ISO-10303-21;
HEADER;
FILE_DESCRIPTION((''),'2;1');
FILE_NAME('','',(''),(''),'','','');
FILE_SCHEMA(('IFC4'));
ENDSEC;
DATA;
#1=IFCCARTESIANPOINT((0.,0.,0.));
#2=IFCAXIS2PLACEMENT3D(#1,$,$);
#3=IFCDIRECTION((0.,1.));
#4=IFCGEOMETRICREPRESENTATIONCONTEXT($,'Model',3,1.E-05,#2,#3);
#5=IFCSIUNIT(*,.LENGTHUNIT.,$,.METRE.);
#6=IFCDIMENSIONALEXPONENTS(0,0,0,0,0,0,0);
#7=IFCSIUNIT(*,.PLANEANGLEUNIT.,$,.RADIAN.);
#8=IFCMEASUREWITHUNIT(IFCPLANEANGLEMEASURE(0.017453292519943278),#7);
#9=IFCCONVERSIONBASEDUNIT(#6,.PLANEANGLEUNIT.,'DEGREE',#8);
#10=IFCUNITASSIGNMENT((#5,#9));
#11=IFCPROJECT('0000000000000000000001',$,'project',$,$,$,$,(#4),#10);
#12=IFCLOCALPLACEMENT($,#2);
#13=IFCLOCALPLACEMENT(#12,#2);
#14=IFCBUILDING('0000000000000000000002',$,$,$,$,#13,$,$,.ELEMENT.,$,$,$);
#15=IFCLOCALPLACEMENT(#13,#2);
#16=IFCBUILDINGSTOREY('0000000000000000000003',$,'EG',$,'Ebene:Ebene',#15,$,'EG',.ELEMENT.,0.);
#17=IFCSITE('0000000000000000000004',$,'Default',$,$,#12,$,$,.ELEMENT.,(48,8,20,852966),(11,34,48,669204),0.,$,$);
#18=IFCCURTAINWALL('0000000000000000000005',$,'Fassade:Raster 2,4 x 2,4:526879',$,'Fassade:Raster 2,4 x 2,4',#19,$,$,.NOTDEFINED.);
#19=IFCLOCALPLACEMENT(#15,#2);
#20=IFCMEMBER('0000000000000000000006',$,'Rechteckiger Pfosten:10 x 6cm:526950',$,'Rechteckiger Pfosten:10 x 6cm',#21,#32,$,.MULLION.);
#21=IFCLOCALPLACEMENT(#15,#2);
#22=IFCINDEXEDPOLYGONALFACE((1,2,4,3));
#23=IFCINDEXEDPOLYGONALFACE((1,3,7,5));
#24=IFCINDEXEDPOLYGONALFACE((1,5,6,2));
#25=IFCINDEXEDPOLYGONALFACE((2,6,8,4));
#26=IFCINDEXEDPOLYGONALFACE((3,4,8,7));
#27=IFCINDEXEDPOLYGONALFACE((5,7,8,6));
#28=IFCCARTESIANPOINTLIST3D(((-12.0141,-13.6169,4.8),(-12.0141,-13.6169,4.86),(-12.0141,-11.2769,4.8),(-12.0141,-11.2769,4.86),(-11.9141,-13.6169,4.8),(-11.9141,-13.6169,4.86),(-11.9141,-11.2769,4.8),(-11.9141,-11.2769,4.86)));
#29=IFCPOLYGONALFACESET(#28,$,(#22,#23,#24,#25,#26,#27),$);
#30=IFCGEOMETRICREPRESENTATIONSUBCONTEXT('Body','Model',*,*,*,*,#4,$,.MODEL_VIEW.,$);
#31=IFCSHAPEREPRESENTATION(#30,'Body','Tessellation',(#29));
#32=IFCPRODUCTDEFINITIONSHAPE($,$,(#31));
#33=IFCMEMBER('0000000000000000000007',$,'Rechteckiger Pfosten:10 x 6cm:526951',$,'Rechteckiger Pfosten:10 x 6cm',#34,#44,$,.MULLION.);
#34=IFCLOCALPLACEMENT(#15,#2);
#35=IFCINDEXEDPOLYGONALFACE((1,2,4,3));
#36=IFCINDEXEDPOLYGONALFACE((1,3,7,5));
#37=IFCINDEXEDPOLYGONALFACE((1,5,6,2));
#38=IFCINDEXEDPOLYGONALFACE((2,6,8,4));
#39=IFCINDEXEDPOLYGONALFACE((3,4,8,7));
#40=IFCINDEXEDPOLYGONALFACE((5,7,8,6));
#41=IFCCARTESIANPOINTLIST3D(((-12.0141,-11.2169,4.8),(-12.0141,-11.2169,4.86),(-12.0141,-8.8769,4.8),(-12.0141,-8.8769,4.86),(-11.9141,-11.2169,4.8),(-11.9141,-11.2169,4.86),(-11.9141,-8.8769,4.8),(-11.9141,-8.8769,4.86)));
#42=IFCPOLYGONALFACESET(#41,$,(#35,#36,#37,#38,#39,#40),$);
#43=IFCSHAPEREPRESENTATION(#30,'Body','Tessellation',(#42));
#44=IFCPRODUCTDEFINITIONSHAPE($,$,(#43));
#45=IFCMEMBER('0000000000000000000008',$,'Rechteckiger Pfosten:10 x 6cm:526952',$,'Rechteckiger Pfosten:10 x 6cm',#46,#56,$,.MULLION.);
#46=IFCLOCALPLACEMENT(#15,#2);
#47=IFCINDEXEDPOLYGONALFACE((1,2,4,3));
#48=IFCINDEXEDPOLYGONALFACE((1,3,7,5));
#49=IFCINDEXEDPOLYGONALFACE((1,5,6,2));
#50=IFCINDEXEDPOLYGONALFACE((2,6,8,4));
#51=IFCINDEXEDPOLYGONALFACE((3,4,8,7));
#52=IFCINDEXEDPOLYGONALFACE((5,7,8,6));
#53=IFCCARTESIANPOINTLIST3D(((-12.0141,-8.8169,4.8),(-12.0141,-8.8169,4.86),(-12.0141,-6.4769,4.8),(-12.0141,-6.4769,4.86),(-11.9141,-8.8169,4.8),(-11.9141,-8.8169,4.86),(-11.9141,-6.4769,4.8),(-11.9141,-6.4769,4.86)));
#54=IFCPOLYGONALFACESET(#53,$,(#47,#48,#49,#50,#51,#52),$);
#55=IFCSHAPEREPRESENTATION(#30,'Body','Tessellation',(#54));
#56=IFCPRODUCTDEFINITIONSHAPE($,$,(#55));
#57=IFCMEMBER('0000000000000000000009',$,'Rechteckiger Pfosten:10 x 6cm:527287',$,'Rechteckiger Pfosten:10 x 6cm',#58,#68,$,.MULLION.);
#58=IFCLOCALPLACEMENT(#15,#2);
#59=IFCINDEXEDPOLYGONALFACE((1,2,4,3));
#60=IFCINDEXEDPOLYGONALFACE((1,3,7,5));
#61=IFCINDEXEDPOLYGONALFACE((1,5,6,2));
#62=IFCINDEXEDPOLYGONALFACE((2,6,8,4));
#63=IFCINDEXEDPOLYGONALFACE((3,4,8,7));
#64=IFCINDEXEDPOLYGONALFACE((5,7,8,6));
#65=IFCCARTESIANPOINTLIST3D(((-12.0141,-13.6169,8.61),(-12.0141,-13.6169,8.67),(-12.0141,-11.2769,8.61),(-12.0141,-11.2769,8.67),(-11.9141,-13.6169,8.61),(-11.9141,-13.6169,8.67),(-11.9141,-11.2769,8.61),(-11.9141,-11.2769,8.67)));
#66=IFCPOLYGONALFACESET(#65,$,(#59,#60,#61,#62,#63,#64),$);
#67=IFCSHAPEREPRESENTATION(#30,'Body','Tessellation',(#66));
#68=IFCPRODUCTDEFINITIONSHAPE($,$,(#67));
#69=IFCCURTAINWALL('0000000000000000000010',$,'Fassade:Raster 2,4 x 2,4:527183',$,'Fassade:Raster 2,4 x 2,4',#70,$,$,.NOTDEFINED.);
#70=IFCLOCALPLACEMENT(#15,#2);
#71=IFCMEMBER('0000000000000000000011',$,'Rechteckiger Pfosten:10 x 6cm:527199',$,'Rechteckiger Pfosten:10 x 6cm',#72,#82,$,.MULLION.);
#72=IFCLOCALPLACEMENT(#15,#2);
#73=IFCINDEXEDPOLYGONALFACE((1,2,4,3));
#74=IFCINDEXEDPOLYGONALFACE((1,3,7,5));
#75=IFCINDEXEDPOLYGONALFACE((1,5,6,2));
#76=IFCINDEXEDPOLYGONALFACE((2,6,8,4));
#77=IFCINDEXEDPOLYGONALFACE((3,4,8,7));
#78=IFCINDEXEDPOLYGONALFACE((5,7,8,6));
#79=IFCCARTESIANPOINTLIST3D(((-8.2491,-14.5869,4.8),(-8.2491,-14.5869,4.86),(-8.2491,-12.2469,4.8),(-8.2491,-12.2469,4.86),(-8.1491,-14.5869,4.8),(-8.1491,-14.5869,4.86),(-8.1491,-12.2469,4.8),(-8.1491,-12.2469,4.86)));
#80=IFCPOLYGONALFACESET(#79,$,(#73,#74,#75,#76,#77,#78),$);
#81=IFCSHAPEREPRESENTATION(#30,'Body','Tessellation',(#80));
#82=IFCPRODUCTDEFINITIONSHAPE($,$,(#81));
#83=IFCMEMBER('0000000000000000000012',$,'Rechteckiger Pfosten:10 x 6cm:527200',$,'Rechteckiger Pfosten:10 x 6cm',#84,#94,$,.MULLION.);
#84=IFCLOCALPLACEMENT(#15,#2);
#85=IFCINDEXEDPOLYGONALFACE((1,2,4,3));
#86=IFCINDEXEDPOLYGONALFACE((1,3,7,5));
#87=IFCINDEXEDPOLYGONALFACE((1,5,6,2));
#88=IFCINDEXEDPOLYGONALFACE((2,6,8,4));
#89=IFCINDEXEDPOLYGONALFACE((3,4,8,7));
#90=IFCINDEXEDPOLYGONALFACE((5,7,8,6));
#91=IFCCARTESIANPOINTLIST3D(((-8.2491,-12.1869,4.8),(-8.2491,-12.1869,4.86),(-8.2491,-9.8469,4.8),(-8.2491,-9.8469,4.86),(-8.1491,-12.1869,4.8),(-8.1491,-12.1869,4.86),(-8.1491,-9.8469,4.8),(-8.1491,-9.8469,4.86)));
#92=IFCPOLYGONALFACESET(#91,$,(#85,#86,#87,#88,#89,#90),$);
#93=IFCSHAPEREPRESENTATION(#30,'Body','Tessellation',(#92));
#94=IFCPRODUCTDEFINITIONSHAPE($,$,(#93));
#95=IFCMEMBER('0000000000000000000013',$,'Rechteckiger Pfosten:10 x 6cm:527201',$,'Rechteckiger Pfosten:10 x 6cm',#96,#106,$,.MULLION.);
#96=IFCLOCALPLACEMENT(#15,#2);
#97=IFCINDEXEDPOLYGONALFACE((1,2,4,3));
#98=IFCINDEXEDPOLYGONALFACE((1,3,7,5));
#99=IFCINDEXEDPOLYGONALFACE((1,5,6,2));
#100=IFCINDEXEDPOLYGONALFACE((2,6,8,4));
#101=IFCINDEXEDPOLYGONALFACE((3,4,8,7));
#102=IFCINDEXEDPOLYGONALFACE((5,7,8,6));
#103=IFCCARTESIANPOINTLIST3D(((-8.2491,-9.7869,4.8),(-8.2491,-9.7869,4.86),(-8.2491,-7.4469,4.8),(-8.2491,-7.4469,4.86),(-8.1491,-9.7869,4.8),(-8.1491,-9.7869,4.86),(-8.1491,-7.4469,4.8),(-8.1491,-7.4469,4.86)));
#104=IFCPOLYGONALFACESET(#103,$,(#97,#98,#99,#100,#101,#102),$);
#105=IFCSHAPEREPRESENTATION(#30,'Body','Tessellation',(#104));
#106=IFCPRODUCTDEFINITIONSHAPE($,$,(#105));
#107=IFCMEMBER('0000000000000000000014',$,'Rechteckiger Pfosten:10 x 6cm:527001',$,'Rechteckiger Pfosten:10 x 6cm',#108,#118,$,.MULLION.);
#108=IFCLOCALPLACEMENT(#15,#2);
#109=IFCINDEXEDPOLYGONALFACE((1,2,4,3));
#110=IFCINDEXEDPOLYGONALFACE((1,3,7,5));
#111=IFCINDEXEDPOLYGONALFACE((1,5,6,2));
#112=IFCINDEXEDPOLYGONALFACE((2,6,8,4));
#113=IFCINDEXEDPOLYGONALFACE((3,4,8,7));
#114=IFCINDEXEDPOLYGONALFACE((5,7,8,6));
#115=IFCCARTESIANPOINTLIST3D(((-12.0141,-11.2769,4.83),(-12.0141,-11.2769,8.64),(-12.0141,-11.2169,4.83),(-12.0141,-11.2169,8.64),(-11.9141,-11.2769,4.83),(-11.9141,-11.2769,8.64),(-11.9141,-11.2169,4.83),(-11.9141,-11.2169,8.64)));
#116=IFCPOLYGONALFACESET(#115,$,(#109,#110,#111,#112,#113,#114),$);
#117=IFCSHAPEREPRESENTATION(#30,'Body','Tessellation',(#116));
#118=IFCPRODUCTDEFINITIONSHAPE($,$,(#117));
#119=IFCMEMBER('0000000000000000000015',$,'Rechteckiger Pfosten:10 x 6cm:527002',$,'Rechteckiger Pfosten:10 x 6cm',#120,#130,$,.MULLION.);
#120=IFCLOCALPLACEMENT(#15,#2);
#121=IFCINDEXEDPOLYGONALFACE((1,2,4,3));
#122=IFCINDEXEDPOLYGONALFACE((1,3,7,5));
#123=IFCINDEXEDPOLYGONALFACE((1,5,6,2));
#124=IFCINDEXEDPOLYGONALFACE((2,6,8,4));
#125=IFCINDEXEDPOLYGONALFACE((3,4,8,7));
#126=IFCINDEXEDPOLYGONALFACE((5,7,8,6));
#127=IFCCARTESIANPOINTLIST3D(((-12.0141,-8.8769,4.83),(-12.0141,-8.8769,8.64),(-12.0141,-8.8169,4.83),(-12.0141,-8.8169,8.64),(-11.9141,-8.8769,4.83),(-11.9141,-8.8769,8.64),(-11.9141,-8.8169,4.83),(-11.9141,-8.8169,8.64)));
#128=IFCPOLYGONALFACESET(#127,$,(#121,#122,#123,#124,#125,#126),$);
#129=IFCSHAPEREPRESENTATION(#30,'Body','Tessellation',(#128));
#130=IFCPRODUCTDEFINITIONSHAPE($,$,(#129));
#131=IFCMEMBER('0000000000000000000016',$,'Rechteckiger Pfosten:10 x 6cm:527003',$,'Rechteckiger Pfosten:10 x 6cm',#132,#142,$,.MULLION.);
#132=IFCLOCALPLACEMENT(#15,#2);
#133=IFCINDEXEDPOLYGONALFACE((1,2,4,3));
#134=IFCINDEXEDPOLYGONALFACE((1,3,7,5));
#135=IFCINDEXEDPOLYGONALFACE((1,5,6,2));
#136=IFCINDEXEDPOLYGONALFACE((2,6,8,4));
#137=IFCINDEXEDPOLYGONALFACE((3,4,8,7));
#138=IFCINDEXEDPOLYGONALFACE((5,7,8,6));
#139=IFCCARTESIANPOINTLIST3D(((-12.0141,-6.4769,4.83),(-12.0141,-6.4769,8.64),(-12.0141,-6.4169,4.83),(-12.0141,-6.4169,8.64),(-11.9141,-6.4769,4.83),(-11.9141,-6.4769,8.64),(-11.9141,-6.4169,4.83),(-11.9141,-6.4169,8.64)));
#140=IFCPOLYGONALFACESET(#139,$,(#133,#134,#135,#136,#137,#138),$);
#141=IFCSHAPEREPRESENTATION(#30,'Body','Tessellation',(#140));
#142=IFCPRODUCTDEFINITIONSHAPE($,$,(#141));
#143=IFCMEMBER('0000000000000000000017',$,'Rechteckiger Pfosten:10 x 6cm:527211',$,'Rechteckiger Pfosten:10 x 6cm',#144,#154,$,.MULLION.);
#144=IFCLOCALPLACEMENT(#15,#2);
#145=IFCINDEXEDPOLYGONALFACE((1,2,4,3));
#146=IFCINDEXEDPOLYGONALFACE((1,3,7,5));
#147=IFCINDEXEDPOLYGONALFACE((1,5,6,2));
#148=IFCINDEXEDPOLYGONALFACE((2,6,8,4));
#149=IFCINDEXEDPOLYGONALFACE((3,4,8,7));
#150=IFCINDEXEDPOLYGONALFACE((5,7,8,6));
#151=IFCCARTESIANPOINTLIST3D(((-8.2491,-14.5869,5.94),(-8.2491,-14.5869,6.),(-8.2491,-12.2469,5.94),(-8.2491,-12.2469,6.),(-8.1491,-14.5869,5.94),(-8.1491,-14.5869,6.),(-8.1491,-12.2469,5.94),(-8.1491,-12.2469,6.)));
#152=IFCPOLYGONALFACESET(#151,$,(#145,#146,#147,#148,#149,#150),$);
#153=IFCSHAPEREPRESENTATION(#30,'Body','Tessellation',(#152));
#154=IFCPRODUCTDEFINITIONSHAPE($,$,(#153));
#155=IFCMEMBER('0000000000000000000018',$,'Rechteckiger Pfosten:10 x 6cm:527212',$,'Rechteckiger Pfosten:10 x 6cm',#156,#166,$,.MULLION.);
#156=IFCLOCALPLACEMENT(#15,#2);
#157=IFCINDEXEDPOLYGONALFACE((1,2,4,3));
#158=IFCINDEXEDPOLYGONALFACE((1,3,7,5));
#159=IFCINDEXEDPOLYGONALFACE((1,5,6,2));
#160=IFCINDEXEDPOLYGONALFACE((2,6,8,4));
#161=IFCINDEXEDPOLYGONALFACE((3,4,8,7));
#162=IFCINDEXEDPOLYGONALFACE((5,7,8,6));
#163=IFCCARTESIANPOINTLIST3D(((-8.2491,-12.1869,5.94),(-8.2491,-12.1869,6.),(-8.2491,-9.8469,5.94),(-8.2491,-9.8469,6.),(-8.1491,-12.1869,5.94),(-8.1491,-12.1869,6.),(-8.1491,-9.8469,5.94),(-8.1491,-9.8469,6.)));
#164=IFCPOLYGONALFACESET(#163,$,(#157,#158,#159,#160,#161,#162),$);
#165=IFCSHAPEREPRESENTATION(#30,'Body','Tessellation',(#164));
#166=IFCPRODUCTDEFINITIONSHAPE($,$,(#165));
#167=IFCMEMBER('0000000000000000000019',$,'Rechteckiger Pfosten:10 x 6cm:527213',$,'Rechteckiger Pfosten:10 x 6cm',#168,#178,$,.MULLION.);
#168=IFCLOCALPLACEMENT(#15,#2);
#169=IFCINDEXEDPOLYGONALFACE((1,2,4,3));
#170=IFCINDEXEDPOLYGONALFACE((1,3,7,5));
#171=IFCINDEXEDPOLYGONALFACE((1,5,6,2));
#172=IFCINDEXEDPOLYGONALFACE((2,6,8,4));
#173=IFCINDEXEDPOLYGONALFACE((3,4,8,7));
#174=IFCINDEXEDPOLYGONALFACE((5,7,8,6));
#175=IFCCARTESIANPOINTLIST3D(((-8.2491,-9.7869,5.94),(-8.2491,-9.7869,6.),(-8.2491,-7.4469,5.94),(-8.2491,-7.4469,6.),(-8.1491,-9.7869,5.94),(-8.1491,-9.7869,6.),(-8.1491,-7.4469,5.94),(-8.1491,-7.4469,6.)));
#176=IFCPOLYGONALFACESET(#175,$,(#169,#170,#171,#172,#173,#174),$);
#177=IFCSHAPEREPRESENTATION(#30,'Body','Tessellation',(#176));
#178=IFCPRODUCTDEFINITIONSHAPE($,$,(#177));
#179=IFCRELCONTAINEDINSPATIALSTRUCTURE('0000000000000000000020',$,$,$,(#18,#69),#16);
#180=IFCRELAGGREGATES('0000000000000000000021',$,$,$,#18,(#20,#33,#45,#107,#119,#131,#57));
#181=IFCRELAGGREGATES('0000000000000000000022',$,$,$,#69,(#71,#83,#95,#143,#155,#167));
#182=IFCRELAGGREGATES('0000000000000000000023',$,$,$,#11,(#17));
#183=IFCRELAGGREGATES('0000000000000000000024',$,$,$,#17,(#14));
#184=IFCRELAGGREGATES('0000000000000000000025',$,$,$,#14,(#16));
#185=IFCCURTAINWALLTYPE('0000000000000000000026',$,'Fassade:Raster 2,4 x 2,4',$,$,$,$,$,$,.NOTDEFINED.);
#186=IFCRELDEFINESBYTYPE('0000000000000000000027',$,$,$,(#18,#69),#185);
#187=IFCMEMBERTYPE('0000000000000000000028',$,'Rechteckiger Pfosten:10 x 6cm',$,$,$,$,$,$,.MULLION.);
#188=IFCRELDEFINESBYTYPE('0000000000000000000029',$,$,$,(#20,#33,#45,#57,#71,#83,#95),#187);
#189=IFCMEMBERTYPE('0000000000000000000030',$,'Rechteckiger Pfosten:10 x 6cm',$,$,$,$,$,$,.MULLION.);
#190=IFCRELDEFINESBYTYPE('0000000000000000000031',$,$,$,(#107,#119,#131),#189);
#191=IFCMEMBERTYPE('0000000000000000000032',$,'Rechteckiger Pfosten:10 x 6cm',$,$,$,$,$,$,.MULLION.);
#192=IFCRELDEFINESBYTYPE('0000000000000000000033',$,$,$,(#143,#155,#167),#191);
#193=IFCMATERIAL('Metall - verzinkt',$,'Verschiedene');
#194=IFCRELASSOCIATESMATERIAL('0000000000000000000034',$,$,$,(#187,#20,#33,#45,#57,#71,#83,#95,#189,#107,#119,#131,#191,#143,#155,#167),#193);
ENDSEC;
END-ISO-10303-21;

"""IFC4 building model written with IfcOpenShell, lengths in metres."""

from ifc_helpers import new_model, entity, si_unit, converted_unit, direction, frame, origin, place, context, subcontext, project, spatial, indexed_curve, outline, extrude, source, transform, mapped, material, type_object, type_shapes, element, aggregate, save


model = new_model("IFC4")

# Units and contexts
model_context = context("Model", 3, precision=1e-05, world=origin(), true_north=direction((0.0, 1.0)))
body_context = subcontext(model_context, "Body", "Model", "MODEL_VIEW")
ifc_project = project(units=[si_unit("LENGTHUNIT", "METRE"), converted_unit("PLANEANGLEUNIT", "DEGREE", entity("IfcPlaneAngleMeasure", 0.017453292519943278), si_unit("PLANEANGLEUNIT", "RADIAN"), dimensions=[0, 0, 0, 0, 0, 0, 0])], contexts=[model_context])

# Site, building, storey
site_placement = place(None, origin())
site = spatial("IfcSite", under=ifc_project, at=site_placement, Name="Default", CompositionType="ELEMENT", RefLatitude=(48, 8, 20, 852966), RefLongitude=(11, 34, 48, 669204), RefElevation=0.0)
building_placement = place(site_placement, origin())
building = spatial("IfcBuilding", under=site, at=building_placement, CompositionType="ELEMENT")
storey_placement = place(building_placement, origin())
storey = spatial("IfcBuildingStorey", under=building, at=storey_placement, Name="EG", ObjectType="Ebene:Ebene", LongName="EG", CompositionType="ELEMENT", Elevation=0.0)

# Curtain walls, members
curtain_wall_type = type_object("IfcCurtainWallType", Name="Fassade:Raster 2,4 x 2,4", PredefinedType="NOTDEFINED")
curtain_wall_1_placement = place(storey_placement, origin())
curtain_wall_1 = element("IfcCurtainWall", 1, at=curtain_wall_1_placement, inside=storey, type_object=curtain_wall_type, Name="Fassade:Raster 2,4 x 2,4:526879", ObjectType="Fassade:Raster 2,4 x 2,4", PredefinedType="NOTDEFINED")
ifc_material_1 = material(Name="Metall - verzinkt", Category="Verschiedene")
member_type_1 = type_object("IfcMemberType", Name="Rechteckiger Pfosten:10 x 6cm", PredefinedType="MULLION", material=ifc_material_1)
shared_shape_1 = source(origin(), body_context, "Body", "SweptSolid", [
    extrude(outline(indexed_curve([(-0.03, -0.05), (0.03, -0.05), (0.03, 0.05), (-0.03, 0.05), (-0.03, -0.05)], self_intersect=False)), frame((0.0, 0.0, -2.34), z_axis=(0.0, 0.0, 1.0), x_axis=(-1.0, 0.0, 0.0)), (0.0, 0.0, 1.0), 2.34),
])
type_shapes(member_type_1, [shared_shape_1])
member_1_placement = place(curtain_wall_1_placement, frame((-11.9641, -11.2769, 4.83), z_axis=(0.0, 1.0, 0.0), x_axis=(0.0, 0.0, 1.0)))
member_1 = element("IfcMember", 2, at=member_1_placement, type_object=member_type_1, material=ifc_material_1, Name="Rechteckiger Pfosten:10 x 6cm:526950", ObjectType="Rechteckiger Pfosten:10 x 6cm", PredefinedType="MULLION", context=body_context, shape_type="MappedRepresentation", body=[
    mapped(shared_shape_1, transform((0.0, 0.0, 0.0), scale=1.0)),
])
member_2_placement = place(curtain_wall_1_placement, frame((-11.9641, -8.8769, 4.83), z_axis=(0.0, 1.0, 0.0), x_axis=(0.0, 0.0, 1.0)))
member_2 = element("IfcMember", 3, at=member_2_placement, type_object=member_type_1, material=ifc_material_1, Name="Rechteckiger Pfosten:10 x 6cm:526951", ObjectType="Rechteckiger Pfosten:10 x 6cm", PredefinedType="MULLION", context=body_context, shape_type="MappedRepresentation", body=[
    mapped(shared_shape_1, transform((0.0, 0.0, 0.0), scale=1.0)),
])
member_3_placement = place(curtain_wall_1_placement, frame((-11.9641, -6.4769, 4.83), z_axis=(0.0, 1.0, 0.0), x_axis=(0.0, 0.0, 1.0)))
member_3 = element("IfcMember", 4, at=member_3_placement, type_object=member_type_1, material=ifc_material_1, Name="Rechteckiger Pfosten:10 x 6cm:526952", ObjectType="Rechteckiger Pfosten:10 x 6cm", PredefinedType="MULLION", context=body_context, shape_type="MappedRepresentation", body=[
    mapped(shared_shape_1, transform((0.0, 0.0, 0.0), scale=1.0)),
])
member_4_placement = place(curtain_wall_1_placement, frame((-11.9641, -11.2769, 8.64), z_axis=(0.0, 1.0, 0.0), x_axis=(0.0, 0.0, 1.0)))
member_4 = element("IfcMember", 5, at=member_4_placement, type_object=member_type_1, material=ifc_material_1, Name="Rechteckiger Pfosten:10 x 6cm:527287", ObjectType="Rechteckiger Pfosten:10 x 6cm", PredefinedType="MULLION", context=body_context, shape_type="MappedRepresentation", body=[
    mapped(shared_shape_1, transform((0.0, 0.0, 0.0), scale=1.0)),
])
curtain_wall_2_placement = place(storey_placement, origin())
curtain_wall_2 = element("IfcCurtainWall", 6, at=curtain_wall_2_placement, inside=storey, type_object=curtain_wall_type, Name="Fassade:Raster 2,4 x 2,4:527183", ObjectType="Fassade:Raster 2,4 x 2,4", PredefinedType="NOTDEFINED")
member_5_placement = place(curtain_wall_2_placement, frame((-8.1991, -12.2469, 4.83), z_axis=(0.0, 1.0, 0.0), x_axis=(0.0, 0.0, 1.0)))
member_5 = element("IfcMember", 7, at=member_5_placement, type_object=member_type_1, material=ifc_material_1, Name="Rechteckiger Pfosten:10 x 6cm:527199", ObjectType="Rechteckiger Pfosten:10 x 6cm", PredefinedType="MULLION", context=body_context, shape_type="MappedRepresentation", body=[
    mapped(shared_shape_1, transform((0.0, 0.0, 0.0), scale=1.0)),
])
member_6_placement = place(curtain_wall_2_placement, frame((-8.1991, -9.8469, 4.83), z_axis=(0.0, 1.0, 0.0), x_axis=(0.0, 0.0, 1.0)))
member_6 = element("IfcMember", 8, at=member_6_placement, type_object=member_type_1, material=ifc_material_1, Name="Rechteckiger Pfosten:10 x 6cm:527200", ObjectType="Rechteckiger Pfosten:10 x 6cm", PredefinedType="MULLION", context=body_context, shape_type="MappedRepresentation", body=[
    mapped(shared_shape_1, transform((0.0, 0.0, 0.0), scale=1.0)),
])
member_7_placement = place(curtain_wall_2_placement, frame((-8.1991, -7.4469, 4.83), z_axis=(0.0, 1.0, 0.0), x_axis=(0.0, 0.0, 1.0)))
member_7 = element("IfcMember", 9, at=member_7_placement, type_object=member_type_1, material=ifc_material_1, Name="Rechteckiger Pfosten:10 x 6cm:527201", ObjectType="Rechteckiger Pfosten:10 x 6cm", PredefinedType="MULLION", context=body_context, shape_type="MappedRepresentation", body=[
    mapped(shared_shape_1, transform((0.0, 0.0, 0.0), scale=1.0)),
])

# Members
member_type_2 = type_object("IfcMemberType", Name="Rechteckiger Pfosten:10 x 6cm", PredefinedType="MULLION", material=ifc_material_1)
shared_shape_2 = source(origin(), body_context, "Body", "SweptSolid", [
    extrude(outline(indexed_curve([(-0.03, -0.05), (0.03, -0.05), (0.03, 0.05), (-0.03, 0.05), (-0.03, -0.05)], self_intersect=False)), frame((0.0, 0.0, -3.81), z_axis=(0.0, 0.0, 1.0), x_axis=(-1.0, 0.0, 0.0)), (0.0, 0.0, 1.0), 3.81),
])
type_shapes(member_type_2, [shared_shape_2])
member_8_placement = place(curtain_wall_1_placement, frame((-11.9641, -11.2469, 4.83), z_axis=(0.0, 0.0, -1.0), x_axis=(0.0, 1.0, 0.0)))
member_8 = element("IfcMember", 10, at=member_8_placement, type_object=member_type_2, material=ifc_material_1, Name="Rechteckiger Pfosten:10 x 6cm:527001", ObjectType="Rechteckiger Pfosten:10 x 6cm", PredefinedType="MULLION", context=body_context, shape_type="MappedRepresentation", body=[
    mapped(shared_shape_2, transform((0.0, 0.0, 0.0), scale=1.0)),
])
member_9_placement = place(curtain_wall_1_placement, frame((-11.9641, -8.8469, 4.83), z_axis=(0.0, 0.0, -1.0), x_axis=(0.0, 1.0, 0.0)))
member_9 = element("IfcMember", 11, at=member_9_placement, type_object=member_type_2, material=ifc_material_1, Name="Rechteckiger Pfosten:10 x 6cm:527002", ObjectType="Rechteckiger Pfosten:10 x 6cm", PredefinedType="MULLION", context=body_context, shape_type="MappedRepresentation", body=[
    mapped(shared_shape_2, transform((0.0, 0.0, 0.0), scale=1.0)),
])
member_10_placement = place(curtain_wall_1_placement, frame((-11.9641, -6.4469, 4.83), z_axis=(0.0, 0.0, -1.0), x_axis=(0.0, 1.0, 0.0)))
member_10 = element("IfcMember", 12, at=member_10_placement, type_object=member_type_2, material=ifc_material_1, Name="Rechteckiger Pfosten:10 x 6cm:527003", ObjectType="Rechteckiger Pfosten:10 x 6cm", PredefinedType="MULLION", context=body_context, shape_type="MappedRepresentation", body=[
    mapped(shared_shape_2, transform((0.0, 0.0, 0.0), scale=1.0)),
])
member_type_3 = type_object("IfcMemberType", Name="Rechteckiger Pfosten:10 x 6cm", PredefinedType="MULLION", material=ifc_material_1)
shared_shape_3 = source(origin(), body_context, "Body", "SweptSolid", [
    extrude(outline(indexed_curve([(-0.03, -0.05), (0.03, -0.05), (0.03, 0.05), (-0.03, 0.05), (-0.03, -0.05)], self_intersect=False)), frame((-0.03, 0.0, -2.34), z_axis=(0.0, 0.0, 1.0), x_axis=(-1.0, 0.0, 0.0)), (0.0, 0.0, 1.0), 2.34),
])
type_shapes(member_type_3, [shared_shape_3])
member_11_placement = place(curtain_wall_2_placement, frame((-8.1991, -12.2469, 6.0), z_axis=(0.0, 1.0, 0.0), x_axis=(0.0, 0.0, 1.0)))
member_11 = element("IfcMember", 13, at=member_11_placement, type_object=member_type_3, material=ifc_material_1, Name="Rechteckiger Pfosten:10 x 6cm:527211", ObjectType="Rechteckiger Pfosten:10 x 6cm", PredefinedType="MULLION", context=body_context, shape_type="MappedRepresentation", body=[
    mapped(shared_shape_3, transform((0.0, 0.0, 0.0), scale=1.0)),
])
member_12_placement = place(curtain_wall_2_placement, frame((-8.1991, -9.8469, 6.0), z_axis=(0.0, 1.0, 0.0), x_axis=(0.0, 0.0, 1.0)))
member_12 = element("IfcMember", 14, at=member_12_placement, type_object=member_type_3, material=ifc_material_1, Name="Rechteckiger Pfosten:10 x 6cm:527212", ObjectType="Rechteckiger Pfosten:10 x 6cm", PredefinedType="MULLION", context=body_context, shape_type="MappedRepresentation", body=[
    mapped(shared_shape_3, transform((0.0, 0.0, 0.0), scale=1.0)),
])
member_13_placement = place(curtain_wall_2_placement, frame((-8.1991, -7.4469, 6.0), z_axis=(0.0, 1.0, 0.0), x_axis=(0.0, 0.0, 1.0)))
member_13 = element("IfcMember", 15, at=member_13_placement, type_object=member_type_3, material=ifc_material_1, Name="Rechteckiger Pfosten:10 x 6cm:527213", ObjectType="Rechteckiger Pfosten:10 x 6cm", PredefinedType="MULLION", context=body_context, shape_type="MappedRepresentation", body=[
    mapped(shared_shape_3, transform((0.0, 0.0, 0.0), scale=1.0)),
])

aggregate(curtain_wall_1, [member_1, member_2, member_3, member_8, member_9, member_10, member_4])
aggregate(curtain_wall_2, [member_5, member_6, member_7, member_11, member_12, member_13])

save(model, "model.ifc")
